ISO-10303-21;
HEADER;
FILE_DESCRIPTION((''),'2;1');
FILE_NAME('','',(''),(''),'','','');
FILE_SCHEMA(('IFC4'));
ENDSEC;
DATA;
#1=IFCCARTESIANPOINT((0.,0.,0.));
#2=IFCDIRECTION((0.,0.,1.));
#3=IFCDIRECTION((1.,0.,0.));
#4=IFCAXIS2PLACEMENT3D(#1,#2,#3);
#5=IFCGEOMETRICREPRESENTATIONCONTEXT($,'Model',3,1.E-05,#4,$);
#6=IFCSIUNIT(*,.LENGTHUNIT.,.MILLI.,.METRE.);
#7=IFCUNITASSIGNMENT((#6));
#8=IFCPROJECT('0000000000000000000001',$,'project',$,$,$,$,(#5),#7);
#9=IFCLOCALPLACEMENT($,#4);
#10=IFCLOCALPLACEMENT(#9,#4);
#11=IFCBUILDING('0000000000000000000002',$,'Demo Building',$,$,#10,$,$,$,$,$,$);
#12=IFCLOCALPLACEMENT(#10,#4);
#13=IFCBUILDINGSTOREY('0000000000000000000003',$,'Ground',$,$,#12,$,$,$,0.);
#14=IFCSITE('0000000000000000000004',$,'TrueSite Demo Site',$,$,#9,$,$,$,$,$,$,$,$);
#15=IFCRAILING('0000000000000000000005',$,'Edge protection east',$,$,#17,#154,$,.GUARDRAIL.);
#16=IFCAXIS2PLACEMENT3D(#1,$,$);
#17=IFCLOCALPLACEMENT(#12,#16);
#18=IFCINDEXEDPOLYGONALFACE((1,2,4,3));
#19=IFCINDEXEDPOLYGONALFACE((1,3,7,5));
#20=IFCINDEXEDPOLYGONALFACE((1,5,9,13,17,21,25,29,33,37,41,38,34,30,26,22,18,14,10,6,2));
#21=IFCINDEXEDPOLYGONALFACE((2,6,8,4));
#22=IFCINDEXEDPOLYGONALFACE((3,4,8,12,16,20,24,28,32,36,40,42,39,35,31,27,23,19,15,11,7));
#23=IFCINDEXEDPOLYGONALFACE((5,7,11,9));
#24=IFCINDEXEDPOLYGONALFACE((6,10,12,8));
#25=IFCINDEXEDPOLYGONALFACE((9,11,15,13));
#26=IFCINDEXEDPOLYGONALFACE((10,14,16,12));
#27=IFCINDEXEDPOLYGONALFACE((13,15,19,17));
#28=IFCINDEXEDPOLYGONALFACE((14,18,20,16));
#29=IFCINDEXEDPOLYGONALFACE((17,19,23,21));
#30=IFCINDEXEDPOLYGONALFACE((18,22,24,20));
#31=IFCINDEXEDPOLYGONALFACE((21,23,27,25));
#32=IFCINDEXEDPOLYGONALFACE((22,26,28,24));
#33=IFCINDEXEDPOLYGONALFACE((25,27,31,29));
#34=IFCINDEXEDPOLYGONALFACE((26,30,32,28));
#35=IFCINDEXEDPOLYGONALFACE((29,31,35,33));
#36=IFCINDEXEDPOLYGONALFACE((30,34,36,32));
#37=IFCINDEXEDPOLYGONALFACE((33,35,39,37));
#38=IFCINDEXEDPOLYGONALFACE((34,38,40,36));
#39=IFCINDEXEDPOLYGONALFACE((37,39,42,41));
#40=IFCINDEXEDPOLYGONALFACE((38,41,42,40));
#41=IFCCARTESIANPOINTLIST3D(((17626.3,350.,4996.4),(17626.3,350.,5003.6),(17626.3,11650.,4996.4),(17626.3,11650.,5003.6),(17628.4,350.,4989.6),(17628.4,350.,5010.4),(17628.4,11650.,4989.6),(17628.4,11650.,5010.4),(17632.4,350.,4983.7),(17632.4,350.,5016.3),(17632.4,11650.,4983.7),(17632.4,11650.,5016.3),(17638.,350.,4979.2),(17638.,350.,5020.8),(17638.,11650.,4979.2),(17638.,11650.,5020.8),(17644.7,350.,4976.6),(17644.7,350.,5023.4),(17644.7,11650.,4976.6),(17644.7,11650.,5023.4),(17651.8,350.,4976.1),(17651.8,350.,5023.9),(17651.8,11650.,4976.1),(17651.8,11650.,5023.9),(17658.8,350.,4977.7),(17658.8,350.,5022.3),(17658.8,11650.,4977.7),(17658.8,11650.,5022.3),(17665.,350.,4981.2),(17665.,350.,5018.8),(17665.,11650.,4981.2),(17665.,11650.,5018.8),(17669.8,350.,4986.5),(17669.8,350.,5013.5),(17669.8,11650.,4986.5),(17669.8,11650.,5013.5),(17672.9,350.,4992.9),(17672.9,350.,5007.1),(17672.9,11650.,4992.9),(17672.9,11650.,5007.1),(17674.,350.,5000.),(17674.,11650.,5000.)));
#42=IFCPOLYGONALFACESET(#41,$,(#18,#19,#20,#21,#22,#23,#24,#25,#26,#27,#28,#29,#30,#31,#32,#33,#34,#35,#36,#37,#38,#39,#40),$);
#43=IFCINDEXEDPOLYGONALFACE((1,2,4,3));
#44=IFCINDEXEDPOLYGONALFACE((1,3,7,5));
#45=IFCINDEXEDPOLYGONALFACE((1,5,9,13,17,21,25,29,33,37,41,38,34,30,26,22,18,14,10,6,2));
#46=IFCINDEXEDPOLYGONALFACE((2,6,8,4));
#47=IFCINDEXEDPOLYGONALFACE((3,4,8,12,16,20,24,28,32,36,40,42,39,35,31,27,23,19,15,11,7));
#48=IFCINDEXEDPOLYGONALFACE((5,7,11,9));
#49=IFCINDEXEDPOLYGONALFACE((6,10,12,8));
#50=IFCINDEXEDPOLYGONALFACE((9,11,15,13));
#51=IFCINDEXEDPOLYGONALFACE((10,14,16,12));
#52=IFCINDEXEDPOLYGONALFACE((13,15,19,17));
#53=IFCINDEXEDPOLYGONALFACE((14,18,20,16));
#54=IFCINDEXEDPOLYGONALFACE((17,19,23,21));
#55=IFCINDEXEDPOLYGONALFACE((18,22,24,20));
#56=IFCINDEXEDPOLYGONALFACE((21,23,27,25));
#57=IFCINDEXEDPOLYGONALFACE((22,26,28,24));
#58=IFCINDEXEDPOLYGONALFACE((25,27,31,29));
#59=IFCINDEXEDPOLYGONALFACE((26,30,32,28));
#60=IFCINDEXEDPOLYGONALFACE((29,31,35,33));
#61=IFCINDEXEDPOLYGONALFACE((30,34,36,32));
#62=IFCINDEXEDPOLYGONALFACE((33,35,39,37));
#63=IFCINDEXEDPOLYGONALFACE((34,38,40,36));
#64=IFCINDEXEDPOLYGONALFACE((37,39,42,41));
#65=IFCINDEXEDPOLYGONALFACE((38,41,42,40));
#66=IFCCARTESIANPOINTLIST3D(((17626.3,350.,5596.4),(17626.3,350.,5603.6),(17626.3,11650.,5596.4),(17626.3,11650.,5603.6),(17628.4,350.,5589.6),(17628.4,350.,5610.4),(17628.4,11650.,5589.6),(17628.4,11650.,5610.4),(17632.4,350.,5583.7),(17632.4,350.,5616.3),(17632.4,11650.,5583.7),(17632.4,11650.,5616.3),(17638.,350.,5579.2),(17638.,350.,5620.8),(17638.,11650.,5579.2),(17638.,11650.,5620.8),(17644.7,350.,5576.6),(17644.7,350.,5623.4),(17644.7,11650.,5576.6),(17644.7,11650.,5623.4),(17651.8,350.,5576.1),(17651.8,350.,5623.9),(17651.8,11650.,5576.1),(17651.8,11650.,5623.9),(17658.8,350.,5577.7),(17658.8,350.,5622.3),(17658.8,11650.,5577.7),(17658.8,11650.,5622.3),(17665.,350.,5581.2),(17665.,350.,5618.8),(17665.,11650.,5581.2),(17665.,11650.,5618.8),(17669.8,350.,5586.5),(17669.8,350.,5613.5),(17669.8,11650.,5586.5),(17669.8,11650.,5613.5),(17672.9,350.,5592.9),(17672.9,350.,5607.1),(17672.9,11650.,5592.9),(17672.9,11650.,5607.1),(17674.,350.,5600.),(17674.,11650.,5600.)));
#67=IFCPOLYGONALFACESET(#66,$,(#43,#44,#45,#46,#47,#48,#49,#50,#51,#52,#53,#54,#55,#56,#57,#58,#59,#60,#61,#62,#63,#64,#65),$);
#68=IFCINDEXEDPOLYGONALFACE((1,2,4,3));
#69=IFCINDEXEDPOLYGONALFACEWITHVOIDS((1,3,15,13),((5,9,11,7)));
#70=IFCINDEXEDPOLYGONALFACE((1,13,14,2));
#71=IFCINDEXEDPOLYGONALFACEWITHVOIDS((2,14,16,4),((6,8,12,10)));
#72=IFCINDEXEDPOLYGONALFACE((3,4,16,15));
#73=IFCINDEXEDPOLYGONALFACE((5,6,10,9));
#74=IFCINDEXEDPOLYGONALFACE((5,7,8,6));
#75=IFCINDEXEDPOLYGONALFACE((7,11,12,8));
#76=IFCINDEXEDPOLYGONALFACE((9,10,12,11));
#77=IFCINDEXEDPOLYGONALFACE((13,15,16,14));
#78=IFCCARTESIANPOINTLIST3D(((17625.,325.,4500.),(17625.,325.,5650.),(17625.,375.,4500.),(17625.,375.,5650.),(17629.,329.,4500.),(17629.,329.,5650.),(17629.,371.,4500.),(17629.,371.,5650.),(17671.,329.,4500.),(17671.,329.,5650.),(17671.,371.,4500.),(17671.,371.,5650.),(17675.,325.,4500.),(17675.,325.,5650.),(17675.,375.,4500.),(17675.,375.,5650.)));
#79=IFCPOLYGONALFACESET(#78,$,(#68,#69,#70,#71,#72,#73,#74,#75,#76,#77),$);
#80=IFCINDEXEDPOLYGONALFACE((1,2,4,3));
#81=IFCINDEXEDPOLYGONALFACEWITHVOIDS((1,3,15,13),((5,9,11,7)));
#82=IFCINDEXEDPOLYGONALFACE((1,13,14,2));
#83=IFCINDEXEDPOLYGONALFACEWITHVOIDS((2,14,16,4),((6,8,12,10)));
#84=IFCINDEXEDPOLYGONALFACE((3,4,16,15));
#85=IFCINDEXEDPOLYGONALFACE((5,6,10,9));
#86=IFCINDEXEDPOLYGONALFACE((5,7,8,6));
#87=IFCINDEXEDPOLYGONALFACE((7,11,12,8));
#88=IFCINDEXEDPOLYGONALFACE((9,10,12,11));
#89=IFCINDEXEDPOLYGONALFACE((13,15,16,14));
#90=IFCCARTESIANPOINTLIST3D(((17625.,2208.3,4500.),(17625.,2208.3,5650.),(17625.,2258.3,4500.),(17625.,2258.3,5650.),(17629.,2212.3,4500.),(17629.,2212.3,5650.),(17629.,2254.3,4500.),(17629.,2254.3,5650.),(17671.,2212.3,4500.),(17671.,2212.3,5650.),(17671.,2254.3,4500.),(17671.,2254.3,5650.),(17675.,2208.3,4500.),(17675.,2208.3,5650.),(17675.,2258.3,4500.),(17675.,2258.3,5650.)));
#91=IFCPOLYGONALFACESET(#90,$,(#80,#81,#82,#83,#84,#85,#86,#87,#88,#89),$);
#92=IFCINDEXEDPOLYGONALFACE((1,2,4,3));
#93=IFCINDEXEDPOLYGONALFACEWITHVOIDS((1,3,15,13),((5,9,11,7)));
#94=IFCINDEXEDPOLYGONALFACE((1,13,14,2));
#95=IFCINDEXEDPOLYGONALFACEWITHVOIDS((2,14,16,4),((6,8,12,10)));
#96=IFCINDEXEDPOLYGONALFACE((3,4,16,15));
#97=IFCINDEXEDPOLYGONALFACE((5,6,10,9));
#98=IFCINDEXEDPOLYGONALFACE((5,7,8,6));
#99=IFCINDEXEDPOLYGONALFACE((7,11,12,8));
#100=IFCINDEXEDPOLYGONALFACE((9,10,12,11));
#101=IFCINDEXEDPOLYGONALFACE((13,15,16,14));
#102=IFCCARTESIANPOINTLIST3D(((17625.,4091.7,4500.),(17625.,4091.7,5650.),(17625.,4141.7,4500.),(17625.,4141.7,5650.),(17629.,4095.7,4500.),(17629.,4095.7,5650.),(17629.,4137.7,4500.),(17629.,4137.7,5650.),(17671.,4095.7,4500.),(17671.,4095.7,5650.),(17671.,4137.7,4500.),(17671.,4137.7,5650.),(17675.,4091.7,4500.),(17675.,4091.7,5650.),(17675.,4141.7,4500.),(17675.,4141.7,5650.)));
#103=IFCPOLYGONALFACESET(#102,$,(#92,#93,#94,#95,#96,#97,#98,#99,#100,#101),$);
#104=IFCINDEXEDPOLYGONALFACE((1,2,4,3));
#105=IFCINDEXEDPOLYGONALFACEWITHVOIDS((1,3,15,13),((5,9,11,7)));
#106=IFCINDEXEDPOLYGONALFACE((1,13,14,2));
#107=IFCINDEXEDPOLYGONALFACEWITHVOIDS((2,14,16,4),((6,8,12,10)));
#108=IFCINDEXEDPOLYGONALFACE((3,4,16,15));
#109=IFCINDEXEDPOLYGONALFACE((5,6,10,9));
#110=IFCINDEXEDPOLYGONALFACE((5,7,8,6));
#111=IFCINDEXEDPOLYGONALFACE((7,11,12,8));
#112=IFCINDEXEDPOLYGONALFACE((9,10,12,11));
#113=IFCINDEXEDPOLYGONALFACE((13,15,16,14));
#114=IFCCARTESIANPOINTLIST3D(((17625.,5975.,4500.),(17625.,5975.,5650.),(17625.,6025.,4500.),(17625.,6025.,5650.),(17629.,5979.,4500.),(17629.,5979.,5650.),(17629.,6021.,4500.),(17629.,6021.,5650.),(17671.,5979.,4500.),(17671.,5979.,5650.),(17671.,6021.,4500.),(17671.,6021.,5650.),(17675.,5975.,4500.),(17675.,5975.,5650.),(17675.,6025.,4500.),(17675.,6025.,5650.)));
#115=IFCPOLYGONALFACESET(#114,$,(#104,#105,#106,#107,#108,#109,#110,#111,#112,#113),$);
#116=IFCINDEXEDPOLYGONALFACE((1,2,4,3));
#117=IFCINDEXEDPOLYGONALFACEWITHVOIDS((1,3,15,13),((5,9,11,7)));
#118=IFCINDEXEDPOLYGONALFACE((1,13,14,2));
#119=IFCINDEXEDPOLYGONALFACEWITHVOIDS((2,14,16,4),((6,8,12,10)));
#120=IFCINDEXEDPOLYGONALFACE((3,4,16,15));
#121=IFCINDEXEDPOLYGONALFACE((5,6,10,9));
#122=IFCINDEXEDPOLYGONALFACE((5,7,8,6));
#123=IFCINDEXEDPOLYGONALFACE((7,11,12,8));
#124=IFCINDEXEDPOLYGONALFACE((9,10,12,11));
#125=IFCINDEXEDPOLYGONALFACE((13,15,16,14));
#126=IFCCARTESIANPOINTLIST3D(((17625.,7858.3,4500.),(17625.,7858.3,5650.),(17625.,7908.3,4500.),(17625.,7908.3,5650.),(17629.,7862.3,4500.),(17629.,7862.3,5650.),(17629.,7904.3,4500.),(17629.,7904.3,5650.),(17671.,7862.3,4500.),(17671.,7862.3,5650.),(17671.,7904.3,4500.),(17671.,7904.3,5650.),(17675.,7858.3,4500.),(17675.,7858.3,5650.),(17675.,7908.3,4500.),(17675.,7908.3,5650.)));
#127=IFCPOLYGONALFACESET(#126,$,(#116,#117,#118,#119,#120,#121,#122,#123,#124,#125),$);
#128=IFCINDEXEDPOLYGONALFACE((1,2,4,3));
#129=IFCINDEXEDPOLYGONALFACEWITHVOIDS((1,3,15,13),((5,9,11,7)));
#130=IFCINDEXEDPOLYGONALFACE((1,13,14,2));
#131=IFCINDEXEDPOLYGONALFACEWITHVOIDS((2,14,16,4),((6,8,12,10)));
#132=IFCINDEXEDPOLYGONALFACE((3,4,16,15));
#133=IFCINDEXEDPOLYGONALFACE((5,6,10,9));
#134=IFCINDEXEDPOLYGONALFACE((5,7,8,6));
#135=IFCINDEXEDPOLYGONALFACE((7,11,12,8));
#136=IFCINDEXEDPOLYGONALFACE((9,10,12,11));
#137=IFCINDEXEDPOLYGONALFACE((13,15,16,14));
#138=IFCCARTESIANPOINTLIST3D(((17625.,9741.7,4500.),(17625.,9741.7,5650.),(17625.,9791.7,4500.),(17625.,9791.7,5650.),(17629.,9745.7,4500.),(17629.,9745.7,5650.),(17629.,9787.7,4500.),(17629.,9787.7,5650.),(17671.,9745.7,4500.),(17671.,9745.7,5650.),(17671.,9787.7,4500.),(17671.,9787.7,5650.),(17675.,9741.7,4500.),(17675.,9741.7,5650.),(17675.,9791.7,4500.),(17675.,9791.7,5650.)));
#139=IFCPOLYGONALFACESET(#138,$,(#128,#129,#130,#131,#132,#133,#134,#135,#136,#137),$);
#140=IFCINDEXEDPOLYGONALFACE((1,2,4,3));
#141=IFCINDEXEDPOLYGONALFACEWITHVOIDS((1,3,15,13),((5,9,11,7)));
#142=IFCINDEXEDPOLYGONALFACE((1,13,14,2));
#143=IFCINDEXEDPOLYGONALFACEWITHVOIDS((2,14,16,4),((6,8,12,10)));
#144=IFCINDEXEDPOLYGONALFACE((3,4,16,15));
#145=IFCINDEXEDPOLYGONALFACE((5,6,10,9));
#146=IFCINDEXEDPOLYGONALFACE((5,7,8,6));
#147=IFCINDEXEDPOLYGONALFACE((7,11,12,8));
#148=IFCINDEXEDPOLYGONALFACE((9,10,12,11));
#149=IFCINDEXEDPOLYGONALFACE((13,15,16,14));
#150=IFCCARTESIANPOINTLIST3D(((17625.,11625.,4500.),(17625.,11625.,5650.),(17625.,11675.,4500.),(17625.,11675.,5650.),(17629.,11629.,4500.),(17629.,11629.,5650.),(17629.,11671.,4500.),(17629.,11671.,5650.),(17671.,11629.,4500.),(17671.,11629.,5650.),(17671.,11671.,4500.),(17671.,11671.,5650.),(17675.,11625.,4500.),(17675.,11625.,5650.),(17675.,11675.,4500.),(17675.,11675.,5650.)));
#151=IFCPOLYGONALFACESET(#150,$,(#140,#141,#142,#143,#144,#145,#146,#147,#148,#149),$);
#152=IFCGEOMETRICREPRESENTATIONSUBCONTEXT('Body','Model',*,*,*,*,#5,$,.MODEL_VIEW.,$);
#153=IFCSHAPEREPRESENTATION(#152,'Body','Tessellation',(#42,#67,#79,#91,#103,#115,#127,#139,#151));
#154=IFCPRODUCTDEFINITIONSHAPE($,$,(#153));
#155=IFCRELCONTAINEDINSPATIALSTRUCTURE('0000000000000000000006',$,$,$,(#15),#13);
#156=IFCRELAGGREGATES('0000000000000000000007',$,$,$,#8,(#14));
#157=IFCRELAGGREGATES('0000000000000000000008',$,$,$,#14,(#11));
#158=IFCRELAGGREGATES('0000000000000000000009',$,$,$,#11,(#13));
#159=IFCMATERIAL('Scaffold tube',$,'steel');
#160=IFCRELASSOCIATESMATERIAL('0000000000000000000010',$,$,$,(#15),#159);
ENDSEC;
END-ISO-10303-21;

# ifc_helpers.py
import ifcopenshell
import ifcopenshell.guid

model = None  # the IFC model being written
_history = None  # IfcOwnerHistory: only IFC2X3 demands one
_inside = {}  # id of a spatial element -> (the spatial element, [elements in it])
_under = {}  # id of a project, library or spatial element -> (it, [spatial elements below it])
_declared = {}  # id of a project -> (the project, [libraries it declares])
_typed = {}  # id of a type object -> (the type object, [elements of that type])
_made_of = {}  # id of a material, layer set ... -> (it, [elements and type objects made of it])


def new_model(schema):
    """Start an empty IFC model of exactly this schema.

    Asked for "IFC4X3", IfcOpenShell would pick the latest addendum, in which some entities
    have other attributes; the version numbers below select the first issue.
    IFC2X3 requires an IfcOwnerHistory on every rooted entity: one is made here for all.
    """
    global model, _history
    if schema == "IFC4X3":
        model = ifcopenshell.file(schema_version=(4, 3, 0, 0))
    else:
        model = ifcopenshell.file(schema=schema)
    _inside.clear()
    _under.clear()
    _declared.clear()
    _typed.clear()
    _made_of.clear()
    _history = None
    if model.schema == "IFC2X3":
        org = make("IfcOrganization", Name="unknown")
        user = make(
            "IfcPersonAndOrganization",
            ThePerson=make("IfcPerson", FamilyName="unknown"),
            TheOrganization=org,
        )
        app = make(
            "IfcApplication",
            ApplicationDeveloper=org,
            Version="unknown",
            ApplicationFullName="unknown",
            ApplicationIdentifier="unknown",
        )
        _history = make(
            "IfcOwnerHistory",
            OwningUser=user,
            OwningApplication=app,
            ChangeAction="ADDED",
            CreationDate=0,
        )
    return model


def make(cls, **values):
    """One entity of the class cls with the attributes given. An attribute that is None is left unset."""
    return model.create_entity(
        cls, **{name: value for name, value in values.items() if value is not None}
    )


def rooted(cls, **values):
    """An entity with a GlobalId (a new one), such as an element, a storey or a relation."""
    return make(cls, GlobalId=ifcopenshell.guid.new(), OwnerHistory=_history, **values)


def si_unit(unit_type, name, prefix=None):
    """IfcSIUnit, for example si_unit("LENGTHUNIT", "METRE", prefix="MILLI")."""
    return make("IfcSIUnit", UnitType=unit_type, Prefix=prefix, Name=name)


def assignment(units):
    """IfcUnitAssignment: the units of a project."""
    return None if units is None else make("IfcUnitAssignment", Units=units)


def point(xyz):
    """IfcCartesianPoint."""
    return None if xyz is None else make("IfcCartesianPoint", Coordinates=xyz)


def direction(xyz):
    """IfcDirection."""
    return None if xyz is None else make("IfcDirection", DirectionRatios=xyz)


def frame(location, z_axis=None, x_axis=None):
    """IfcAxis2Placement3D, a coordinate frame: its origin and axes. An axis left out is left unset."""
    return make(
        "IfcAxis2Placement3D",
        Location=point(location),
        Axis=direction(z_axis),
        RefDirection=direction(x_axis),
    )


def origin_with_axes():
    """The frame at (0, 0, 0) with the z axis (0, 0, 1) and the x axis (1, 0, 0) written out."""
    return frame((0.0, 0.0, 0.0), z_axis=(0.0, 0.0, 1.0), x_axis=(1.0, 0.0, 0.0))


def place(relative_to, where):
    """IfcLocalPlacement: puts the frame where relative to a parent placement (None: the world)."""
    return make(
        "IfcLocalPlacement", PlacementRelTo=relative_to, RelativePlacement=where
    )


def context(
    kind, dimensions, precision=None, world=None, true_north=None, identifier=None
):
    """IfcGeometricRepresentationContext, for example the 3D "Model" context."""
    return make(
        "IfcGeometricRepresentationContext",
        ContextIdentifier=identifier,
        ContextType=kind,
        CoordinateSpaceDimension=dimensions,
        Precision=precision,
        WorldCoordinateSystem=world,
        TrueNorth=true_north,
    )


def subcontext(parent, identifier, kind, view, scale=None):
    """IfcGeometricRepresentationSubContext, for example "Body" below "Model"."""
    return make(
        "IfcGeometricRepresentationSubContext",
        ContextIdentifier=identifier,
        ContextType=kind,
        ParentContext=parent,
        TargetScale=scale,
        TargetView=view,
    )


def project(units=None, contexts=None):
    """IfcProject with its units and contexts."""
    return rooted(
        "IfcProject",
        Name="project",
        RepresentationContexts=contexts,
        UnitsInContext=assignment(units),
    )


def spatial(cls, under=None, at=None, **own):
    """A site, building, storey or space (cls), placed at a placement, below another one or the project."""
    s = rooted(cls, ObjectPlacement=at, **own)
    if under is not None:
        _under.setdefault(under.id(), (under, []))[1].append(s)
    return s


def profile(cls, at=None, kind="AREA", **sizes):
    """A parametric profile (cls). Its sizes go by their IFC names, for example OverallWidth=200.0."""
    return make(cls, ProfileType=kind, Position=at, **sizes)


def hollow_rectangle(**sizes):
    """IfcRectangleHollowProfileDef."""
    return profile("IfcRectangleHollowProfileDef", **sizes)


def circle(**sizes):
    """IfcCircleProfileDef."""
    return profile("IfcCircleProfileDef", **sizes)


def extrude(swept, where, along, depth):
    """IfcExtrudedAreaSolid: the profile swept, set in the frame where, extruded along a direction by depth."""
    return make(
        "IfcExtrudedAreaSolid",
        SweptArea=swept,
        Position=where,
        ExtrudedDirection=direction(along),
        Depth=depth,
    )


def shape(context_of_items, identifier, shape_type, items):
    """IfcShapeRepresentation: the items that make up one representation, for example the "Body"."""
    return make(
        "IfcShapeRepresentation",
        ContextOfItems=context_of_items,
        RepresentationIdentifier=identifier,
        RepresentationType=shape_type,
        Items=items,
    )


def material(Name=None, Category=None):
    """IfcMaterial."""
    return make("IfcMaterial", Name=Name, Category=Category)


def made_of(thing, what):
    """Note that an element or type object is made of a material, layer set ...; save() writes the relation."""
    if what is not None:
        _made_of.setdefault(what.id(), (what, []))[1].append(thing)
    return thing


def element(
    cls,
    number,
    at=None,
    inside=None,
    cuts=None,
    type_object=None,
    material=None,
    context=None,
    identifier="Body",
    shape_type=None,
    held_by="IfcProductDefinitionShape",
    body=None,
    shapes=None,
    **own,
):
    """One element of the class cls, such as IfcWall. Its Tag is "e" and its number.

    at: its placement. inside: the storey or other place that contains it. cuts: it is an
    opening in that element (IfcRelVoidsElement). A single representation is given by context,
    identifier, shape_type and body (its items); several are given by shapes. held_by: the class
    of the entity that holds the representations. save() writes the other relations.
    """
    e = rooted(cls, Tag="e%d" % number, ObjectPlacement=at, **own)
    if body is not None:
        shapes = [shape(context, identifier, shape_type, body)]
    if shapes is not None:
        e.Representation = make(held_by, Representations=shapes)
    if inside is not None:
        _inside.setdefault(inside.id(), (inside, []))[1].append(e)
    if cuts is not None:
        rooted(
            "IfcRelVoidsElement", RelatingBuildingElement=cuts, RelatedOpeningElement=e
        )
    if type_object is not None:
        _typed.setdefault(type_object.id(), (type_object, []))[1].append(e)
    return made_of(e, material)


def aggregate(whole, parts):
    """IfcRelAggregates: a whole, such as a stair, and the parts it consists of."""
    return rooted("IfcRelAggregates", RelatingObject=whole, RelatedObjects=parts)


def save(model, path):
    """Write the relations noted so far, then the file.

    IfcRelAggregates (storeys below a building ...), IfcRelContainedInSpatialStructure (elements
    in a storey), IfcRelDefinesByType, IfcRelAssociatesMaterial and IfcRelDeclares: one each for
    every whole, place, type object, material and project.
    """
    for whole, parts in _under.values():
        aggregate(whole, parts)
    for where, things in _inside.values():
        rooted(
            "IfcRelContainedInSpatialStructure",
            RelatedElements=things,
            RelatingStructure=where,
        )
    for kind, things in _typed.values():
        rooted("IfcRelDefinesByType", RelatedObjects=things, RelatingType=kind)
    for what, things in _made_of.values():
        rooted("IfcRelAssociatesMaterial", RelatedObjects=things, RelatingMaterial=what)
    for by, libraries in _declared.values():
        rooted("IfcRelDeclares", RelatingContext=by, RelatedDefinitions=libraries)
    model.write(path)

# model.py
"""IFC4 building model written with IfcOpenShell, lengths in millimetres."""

from ifc_helpers import new_model, si_unit, frame, origin_with_axes, place, context, subcontext, project, spatial, hollow_rectangle, circle, extrude, material, element, save


model = new_model("IFC4")

# Units and contexts
model_context = context("Model", 3, precision=1e-05, world=origin_with_axes())
body_context = subcontext(model_context, "Body", "Model", "MODEL_VIEW")
ifc_project = project(units=[si_unit("LENGTHUNIT", "METRE", prefix="MILLI")], contexts=[model_context])

# Site, building, storey
site_placement = place(None, origin_with_axes())
site = spatial("IfcSite", under=ifc_project, at=site_placement, Name="TrueSite Demo Site")
building_placement = place(site_placement, origin_with_axes())
building = spatial("IfcBuilding", under=site, at=building_placement, Name="Demo Building")
storey_placement = place(building_placement, origin_with_axes())
storey = spatial("IfcBuildingStorey", under=building, at=storey_placement, Name="Ground", Elevation=0.0)

# Railing
ifc_material_1 = material(Name="Scaffold tube", Category="steel")
railing_1_placement = place(storey_placement, origin_with_axes())
element("IfcRailing", 1, at=railing_1_placement, inside=storey, material=ifc_material_1, Name="Edge protection east", PredefinedType="GUARDRAIL", context=body_context, shape_type="SweptSolid", body=[
    extrude(circle(Radius=24.0), frame((17650.0, 350.0, 5000.0), z_axis=(0.0, 1.0, 0.0), x_axis=(1.0, 0.0, 0.0)), (0.0, 0.0, 1.0), 11300.0),
    extrude(circle(Radius=24.0), frame((17650.0, 350.0, 5600.0), z_axis=(0.0, 1.0, 0.0), x_axis=(1.0, 0.0, 0.0)), (0.0, 0.0, 1.0), 11300.0),
    extrude(hollow_rectangle(XDim=50.0, YDim=50.0, WallThickness=4.0), frame((17650.0, 350.0, 4500.0), z_axis=(0.0, 0.0, 1.0), x_axis=(1.0, 0.0, 0.0)), (0.0, 0.0, 1.0), 1150.0),
    extrude(hollow_rectangle(XDim=50.0, YDim=50.0, WallThickness=4.0), frame((17650.0, 2233.3, 4500.0), z_axis=(0.0, 0.0, 1.0), x_axis=(1.0, 0.0, 0.0)), (0.0, 0.0, 1.0), 1150.0),
    extrude(hollow_rectangle(XDim=50.0, YDim=50.0, WallThickness=4.0), frame((17650.0, 4116.7, 4500.0), z_axis=(0.0, 0.0, 1.0), x_axis=(1.0, 0.0, 0.0)), (0.0, 0.0, 1.0), 1150.0),
    extrude(hollow_rectangle(XDim=50.0, YDim=50.0, WallThickness=4.0), frame((17650.0, 6000.0, 4500.0), z_axis=(0.0, 0.0, 1.0), x_axis=(1.0, 0.0, 0.0)), (0.0, 0.0, 1.0), 1150.0),
    extrude(hollow_rectangle(XDim=50.0, YDim=50.0, WallThickness=4.0), frame((17650.0, 7883.3, 4500.0), z_axis=(0.0, 0.0, 1.0), x_axis=(1.0, 0.0, 0.0)), (0.0, 0.0, 1.0), 1150.0),
    extrude(hollow_rectangle(XDim=50.0, YDim=50.0, WallThickness=4.0), frame((17650.0, 9766.7, 4500.0), z_axis=(0.0, 0.0, 1.0), x_axis=(1.0, 0.0, 0.0)), (0.0, 0.0, 1.0), 1150.0),
    extrude(hollow_rectangle(XDim=50.0, YDim=50.0, WallThickness=4.0), frame((17650.0, 11650.0, 4500.0), z_axis=(0.0, 0.0, 1.0), x_axis=(1.0, 0.0, 0.0)), (0.0, 0.0, 1.0), 1150.0),
])

save(model, "model.ifc")
